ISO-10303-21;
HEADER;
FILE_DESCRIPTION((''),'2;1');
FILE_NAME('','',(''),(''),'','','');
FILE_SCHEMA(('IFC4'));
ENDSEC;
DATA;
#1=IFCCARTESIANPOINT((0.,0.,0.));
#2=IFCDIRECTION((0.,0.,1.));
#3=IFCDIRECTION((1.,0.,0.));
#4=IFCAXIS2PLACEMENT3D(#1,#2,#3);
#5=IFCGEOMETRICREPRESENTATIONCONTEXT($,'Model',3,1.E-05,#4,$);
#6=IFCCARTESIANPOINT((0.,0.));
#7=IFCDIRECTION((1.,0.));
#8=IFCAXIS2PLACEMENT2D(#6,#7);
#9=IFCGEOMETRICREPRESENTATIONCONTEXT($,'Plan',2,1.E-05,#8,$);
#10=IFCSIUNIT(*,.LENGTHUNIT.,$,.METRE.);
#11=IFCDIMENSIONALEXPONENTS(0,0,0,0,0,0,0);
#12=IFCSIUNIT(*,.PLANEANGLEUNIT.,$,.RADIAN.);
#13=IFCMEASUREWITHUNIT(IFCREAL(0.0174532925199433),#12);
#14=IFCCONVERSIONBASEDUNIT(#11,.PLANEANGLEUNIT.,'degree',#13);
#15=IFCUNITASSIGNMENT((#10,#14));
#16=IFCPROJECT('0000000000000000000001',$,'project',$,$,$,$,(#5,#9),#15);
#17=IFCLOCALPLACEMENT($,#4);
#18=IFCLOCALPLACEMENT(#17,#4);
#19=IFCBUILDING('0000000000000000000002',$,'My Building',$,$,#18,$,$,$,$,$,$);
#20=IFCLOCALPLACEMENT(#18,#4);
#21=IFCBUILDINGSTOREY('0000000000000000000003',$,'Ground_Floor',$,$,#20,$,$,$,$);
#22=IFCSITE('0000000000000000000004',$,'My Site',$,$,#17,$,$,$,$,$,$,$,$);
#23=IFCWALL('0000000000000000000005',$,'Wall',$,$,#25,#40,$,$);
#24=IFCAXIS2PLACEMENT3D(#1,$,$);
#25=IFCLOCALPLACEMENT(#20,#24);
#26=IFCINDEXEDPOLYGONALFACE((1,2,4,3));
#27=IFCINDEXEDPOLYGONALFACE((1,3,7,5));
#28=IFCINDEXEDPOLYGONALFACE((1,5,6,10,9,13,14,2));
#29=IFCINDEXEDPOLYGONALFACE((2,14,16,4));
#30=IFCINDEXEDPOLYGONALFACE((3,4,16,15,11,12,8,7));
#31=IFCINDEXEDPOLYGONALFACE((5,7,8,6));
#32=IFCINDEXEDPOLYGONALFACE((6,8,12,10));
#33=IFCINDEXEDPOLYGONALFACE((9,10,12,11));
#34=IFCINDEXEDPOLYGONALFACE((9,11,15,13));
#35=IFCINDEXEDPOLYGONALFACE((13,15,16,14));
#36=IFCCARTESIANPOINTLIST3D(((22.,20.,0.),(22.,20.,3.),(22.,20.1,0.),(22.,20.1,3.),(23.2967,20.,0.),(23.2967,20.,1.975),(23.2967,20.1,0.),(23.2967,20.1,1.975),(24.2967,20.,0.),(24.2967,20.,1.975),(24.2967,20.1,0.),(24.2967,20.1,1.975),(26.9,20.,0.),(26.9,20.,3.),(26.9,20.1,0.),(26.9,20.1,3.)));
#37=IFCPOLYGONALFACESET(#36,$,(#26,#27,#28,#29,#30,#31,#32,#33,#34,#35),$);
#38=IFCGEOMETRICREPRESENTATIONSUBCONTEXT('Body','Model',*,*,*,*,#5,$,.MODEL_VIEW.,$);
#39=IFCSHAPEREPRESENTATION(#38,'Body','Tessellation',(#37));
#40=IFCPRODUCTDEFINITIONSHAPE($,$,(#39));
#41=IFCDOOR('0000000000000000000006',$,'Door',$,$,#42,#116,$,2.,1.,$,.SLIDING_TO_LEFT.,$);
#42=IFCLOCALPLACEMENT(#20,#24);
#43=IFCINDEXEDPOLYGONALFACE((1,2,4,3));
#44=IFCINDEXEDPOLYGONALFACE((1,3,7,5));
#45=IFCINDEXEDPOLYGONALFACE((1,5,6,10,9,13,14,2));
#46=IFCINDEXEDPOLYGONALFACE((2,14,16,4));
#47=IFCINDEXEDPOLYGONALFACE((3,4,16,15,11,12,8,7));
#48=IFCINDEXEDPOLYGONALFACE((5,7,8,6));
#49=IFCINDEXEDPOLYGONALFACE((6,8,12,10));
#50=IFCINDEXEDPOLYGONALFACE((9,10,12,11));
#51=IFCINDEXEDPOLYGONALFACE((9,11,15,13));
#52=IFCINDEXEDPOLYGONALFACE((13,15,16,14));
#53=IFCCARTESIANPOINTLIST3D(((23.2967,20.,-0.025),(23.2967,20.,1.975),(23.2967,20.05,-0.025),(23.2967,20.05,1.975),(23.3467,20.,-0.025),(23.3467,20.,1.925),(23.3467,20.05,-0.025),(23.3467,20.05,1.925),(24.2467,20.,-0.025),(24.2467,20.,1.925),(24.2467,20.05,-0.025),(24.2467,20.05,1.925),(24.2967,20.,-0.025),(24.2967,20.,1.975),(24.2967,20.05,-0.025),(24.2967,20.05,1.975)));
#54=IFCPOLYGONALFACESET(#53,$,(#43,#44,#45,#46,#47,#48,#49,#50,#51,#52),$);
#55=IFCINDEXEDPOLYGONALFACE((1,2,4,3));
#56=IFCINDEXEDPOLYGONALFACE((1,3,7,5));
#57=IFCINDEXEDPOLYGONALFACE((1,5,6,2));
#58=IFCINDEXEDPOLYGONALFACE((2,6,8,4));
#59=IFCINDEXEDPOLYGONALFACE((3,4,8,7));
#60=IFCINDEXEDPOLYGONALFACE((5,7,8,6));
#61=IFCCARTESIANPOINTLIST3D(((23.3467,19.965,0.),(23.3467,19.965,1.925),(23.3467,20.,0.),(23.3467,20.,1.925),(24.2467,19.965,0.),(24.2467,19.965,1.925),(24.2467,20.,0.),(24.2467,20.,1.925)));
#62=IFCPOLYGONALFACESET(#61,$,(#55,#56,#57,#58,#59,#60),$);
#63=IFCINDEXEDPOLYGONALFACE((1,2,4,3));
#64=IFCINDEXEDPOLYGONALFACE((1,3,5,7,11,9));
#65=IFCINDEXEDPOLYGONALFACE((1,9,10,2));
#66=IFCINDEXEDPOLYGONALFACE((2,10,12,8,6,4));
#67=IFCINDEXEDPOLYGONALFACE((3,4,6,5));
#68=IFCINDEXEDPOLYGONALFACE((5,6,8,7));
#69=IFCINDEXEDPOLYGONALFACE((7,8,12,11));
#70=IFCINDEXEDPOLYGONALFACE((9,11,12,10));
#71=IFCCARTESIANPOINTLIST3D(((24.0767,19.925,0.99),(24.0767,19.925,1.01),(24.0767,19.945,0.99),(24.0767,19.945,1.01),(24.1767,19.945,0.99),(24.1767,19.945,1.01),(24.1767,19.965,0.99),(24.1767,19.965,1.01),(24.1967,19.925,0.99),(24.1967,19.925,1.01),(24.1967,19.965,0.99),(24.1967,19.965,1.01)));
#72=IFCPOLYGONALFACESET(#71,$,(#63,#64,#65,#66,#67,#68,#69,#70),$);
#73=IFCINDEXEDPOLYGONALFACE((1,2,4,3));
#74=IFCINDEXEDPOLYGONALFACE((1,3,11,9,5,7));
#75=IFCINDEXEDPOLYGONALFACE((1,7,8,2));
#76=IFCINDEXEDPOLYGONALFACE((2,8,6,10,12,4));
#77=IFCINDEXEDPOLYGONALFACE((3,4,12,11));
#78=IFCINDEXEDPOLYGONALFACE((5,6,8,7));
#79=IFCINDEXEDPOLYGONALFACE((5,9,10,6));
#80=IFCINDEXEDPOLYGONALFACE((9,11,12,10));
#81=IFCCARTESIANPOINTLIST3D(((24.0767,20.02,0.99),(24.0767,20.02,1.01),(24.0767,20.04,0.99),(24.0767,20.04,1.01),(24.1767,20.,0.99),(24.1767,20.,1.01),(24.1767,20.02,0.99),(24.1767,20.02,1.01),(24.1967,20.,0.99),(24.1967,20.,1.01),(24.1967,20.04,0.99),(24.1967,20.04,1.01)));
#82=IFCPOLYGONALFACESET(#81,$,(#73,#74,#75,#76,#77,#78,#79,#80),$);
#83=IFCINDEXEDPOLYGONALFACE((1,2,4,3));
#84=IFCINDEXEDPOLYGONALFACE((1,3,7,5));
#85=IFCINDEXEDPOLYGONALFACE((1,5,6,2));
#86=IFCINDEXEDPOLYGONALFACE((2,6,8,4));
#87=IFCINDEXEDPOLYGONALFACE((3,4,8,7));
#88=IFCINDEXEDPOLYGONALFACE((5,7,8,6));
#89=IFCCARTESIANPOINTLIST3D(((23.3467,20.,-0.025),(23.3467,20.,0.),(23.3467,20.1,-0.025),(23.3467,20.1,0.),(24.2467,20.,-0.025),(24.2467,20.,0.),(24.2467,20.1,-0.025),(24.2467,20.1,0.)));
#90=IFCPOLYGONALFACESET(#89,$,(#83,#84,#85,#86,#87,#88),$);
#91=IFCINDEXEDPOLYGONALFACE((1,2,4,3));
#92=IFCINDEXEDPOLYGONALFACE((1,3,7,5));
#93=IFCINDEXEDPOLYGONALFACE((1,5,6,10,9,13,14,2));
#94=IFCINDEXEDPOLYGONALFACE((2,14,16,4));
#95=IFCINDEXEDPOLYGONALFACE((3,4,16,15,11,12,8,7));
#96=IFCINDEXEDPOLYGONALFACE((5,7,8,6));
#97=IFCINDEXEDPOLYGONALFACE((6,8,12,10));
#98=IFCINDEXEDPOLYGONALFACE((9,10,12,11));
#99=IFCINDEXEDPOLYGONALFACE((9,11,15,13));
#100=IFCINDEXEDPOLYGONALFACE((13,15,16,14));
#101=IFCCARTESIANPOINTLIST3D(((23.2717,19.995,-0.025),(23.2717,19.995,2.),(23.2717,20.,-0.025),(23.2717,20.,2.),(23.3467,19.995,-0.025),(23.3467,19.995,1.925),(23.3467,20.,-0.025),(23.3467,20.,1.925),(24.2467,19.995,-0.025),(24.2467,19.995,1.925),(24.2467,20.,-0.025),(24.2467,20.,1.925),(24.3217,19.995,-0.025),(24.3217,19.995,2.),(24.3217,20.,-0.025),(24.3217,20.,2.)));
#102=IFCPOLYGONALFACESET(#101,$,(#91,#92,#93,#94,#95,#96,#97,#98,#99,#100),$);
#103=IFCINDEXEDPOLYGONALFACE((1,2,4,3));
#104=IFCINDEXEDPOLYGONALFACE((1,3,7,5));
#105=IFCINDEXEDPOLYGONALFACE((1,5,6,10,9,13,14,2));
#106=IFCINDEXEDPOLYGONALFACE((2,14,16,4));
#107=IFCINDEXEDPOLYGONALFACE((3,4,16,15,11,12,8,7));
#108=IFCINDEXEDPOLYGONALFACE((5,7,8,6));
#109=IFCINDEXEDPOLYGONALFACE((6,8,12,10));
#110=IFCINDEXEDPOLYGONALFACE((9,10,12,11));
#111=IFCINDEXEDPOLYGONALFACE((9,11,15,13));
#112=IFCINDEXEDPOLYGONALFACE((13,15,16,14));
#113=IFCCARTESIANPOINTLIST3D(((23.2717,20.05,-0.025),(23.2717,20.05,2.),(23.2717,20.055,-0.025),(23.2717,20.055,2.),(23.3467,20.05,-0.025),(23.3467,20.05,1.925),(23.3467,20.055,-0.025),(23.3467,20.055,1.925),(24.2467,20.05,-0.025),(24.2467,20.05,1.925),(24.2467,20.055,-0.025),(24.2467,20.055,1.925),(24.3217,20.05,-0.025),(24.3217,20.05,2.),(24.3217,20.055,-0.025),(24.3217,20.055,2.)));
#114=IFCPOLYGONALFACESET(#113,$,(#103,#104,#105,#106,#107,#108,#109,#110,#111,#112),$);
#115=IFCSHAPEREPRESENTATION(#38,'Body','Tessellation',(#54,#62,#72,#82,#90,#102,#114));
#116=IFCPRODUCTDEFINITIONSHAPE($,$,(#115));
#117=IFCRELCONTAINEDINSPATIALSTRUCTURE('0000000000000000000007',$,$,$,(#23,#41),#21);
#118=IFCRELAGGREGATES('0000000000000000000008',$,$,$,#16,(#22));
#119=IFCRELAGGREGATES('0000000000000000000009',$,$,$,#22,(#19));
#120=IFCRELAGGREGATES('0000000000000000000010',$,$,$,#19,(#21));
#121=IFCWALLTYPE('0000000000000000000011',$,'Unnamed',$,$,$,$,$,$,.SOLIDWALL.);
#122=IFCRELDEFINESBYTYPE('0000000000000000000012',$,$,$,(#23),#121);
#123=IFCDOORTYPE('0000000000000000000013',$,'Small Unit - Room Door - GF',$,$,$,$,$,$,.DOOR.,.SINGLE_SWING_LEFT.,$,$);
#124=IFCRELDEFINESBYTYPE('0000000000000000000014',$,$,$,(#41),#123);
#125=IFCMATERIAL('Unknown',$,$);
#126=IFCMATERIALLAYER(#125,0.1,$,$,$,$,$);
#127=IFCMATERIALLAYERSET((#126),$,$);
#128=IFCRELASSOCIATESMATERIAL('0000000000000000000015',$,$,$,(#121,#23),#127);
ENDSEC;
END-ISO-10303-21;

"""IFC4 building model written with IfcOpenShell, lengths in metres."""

from ifc_helpers import new_model, entity, si_unit, converted_unit, frame, origin_with_axes, origin_2d_with_axis, place, context, subcontext, project, spatial, line, indexed_curve, outline, extrude, shape, source, transform, mapped, material, layer, layer_set, layer_usage, type_object, type_shapes, element, fill, save


model = new_model("IFC4")

# Units and contexts
model_context = context("Model", 3, precision=1e-05, world=origin_with_axes())
plan_context = context("Plan", 2, precision=1e-05, world=origin_2d_with_axis())
body_context_1 = subcontext(model_context, "Body", "Model", "MODEL_VIEW")
body_context_2 = subcontext(plan_context, "Body", "Plan", "PLAN_VIEW")
ifc_project = project(units=[si_unit("LENGTHUNIT", "METRE"), converted_unit("PLANEANGLEUNIT", "degree", entity("IfcReal", 0.0174532925199433), si_unit("PLANEANGLEUNIT", "RADIAN"), dimensions=[0, 0, 0, 0, 0, 0, 0])], contexts=[model_context, plan_context])

# Site, building, storey
site_placement = place(None, origin_with_axes())
site = spatial("IfcSite", under=ifc_project, at=site_placement, Name="My Site")
building_placement = place(site_placement, origin_with_axes())
building = spatial("IfcBuilding", under=site, at=building_placement, Name="My Building")
storey_placement = place(building_placement, origin_with_axes())
storey = spatial("IfcBuildingStorey", under=building, at=storey_placement, Name="Ground_Floor")

# Shared definitions
ifc_material = material(Name="Unknown")
ifc_layer = layer(ifc_material, 0.1)
ifc_layer_set = layer_set([ifc_layer])
wall_type = type_object("IfcWallType", Name="Unnamed", PredefinedType="SOLIDWALL", material=ifc_layer_set)

# Shared definitions
shared_shape_1 = source(origin_with_axes(), body_context_1, "Body", "SweptSolid", [
    extrude(outline(indexed_curve([(0.0, 0.0), (1.0, 0.0), (1.0, 2.0), (0.0, 2.0)], segments=[line(1, 2, 3, 4, 1)])), frame((0.0, -0.6, 0.0), z_axis=(0.0, -1.0, 0.0), x_axis=(1.0, 0.0, 0.0)), (0.0, 0.0, -1.0), 1.2),
])
door_type_1 = type_object("IfcDoorType", Name="Small Unit - Room Door - GF", OperationType="SINGLE_SWING_LEFT", PredefinedType="DOOR")
shared_shape_2 = source(origin_with_axes(), body_context_1, "Body", "SweptSolid", [
    extrude(outline(indexed_curve([(0.0, 0.0), (0.0, 2.0), (1.0, 2.0), (1.0, 0.0), (0.95, 0.0), (0.95, 1.95), (0.05, 1.95), (0.05, 0.0)], segments=[line(1, 2, 3, 4, 5, 6, 7, 8, 1)])), frame((0.0, 0.0, 0.0), z_axis=(0.0, -1.0, 0.0), x_axis=(1.0, 0.0, 0.0)), (0.0, 0.0, -1.0), 0.05),
    extrude(outline(indexed_curve([(0.0, 0.0), (0.9, 0.0), (0.9, 0.035), (0.0, 0.035)], segments=[line(1, 2, 3, 4, 1)])), frame((0.05, -0.035, 0.025), z_axis=(0.0, 0.0, 1.0), x_axis=(1.0, 0.0, 0.0)), (0.0, 0.0, 1.0), 1.925),
    extrude(outline(indexed_curve([(0.0, 0.0), (0.0, -0.04), (-0.12, -0.04), (-0.12, -0.02), (-0.02, -0.02), (-0.02, 0.0)], segments=[line(1, 2, 3, 4, 5, 6, 1)])), frame((0.9, -0.035, 1.015), z_axis=(0.0, 0.0, 1.0), x_axis=(1.0, 0.0, 0.0)), (0.0, 0.0, 1.0), 0.02),
    extrude(outline(indexed_curve([(0.0, 0.0), (0.0, 0.04), (-0.12, 0.04), (-0.12, 0.02), (-0.02, 0.02), (-0.02, 0.0)], segments=[line(1, 2, 3, 4, 5, 6, 1)])), frame((0.9, 0.0, 1.015), z_axis=(0.0, 0.0, 1.0), x_axis=(1.0, 0.0, 0.0)), (0.0, 0.0, 1.0), 0.02),
    extrude(outline(indexed_curve([(0.0, 0.0), (0.9, 0.0), (0.9, 0.1), (0.0, 0.1)], segments=[line(1, 2, 3, 4, 1)])), frame((0.05, 0.0, 0.0), z_axis=(0.0, 0.0, 1.0), x_axis=(1.0, 0.0, 0.0)), (0.0, 0.0, 1.0), 0.025),
    extrude(outline(indexed_curve([(0.0, 0.0), (0.0, 2.025), (1.05, 2.025), (1.05, 0.0), (0.975, 0.0), (0.975, 1.95), (0.075, 1.95), (0.075, 0.0)], segments=[line(1, 2, 3, 4, 5, 6, 7, 8, 1)])), frame((-0.025, -0.005, 0.0), z_axis=(0.0, -1.0, 0.0), x_axis=(1.0, 0.0, 0.0)), (0.0, 0.0, -1.0), 0.005),
    extrude(outline(indexed_curve([(0.0, 0.0), (0.0, 2.025), (1.05, 2.025), (1.05, 0.0), (0.975, 0.0), (0.975, 1.95), (0.075, 1.95), (0.075, 0.0)], segments=[line(1, 2, 3, 4, 5, 6, 7, 8, 1)])), frame((-0.025, 0.05, 0.0), z_axis=(0.0, -1.0, 0.0), x_axis=(1.0, 0.0, 0.0)), (0.0, 0.0, -1.0), 0.005),
])
shared_shape_3 = source(origin_with_axes(), body_context_2, "Body", "Curve2D", [
    entity("IfcIndexedPolyCurve", entity("IfcCartesianPointList2D", [[0.0, 0.0], [0.05, 0.0], [0.05, 0.05], [0.0, 0.05]]), [entity("IfcLineIndex", [1, 2, 3, 4, 1])]),
    entity("IfcIndexedPolyCurve", entity("IfcCartesianPointList2D", [[1.0, 0.0], [0.95, 0.0], [0.95, 0.05], [1.0, 0.05]]), [entity("IfcLineIndex", [1, 2, 3, 4, 1])]),
    entity("IfcIndexedPolyCurve", entity("IfcCartesianPointList2D", [[-0.4, -0.035], [0.5, -0.035], [0.5, 0.0], [-0.4, 0.0]]), [entity("IfcLineIndex", [1, 2, 3, 4, 1])]),
])
type_shapes(door_type_1, [shared_shape_2, shared_shape_3])

# Wall, opening, door
ifc_layer_usage_1 = layer_usage(ifc_layer_set, "AXIS2", "POSITIVE", 0.0)
wall_1_placement = place(storey_placement, frame((22.0, 20.0, 0.0), z_axis=(0.0, 0.0, 1.0), x_axis=(1.0, 0.0, 0.0)))
wall_1 = element("IfcWall", 1, at=wall_1_placement, inside=storey, type_object=wall_type, material=ifc_layer_usage_1, Name="Wall", context=body_context_1, shape_type="SweptSolid", body=[
    extrude(outline(indexed_curve([(0.0, 0.0), (0.0, 0.1), (4.9, 0.1), (4.9, 0.0)], segments=[line(1, 2, 3, 4, 1)])), origin_with_axes(), (0.0, 0.0, 1.0), 3.0),
])
opening_1_placement = place(wall_1_placement, frame((1.2967, 0.0, -0.025), z_axis=(0.0, 0.0, 1.0), x_axis=(1.0, 0.0, 0.0)))
opening_1 = element("IfcOpeningElement", 2, at=opening_1_placement, cuts=wall_1, PredefinedType="OPENING", context=body_context_1, shape_type="MappedRepresentation", body=[
    mapped(shared_shape_1, transform((0.0, 0.0, 0.0), x_axis=(1.0, 0.0, 0.0), y_axis=(0.0, 1.0, 0.0), z_axis=(0.0, 0.0, 1.0), scale=1.0)),
])
door_1_placement = place(opening_1_placement, frame((0.0, 0.0, 0.0), z_axis=(0.0, 0.0, 1.0), x_axis=(1.0, 0.0, 0.0)))
door_1 = element("IfcDoor", 3, at=door_1_placement, inside=storey, type_object=door_type_1, Name="Door", OperationType="SLIDING_TO_LEFT", OverallHeight=2.0, OverallWidth=1.0, shapes=[
    shape(body_context_1, "Body", "MappedRepresentation", [mapped(shared_shape_2, transform((0.0, 0.0, 0.0), x_axis=(1.0, 0.0, 0.0), y_axis=(0.0, 1.0, 0.0), z_axis=(0.0, 0.0, 1.0), scale=1.0))]),
    shape(body_context_2, "Body", "MappedRepresentation", [mapped(shared_shape_3, transform((0.0, 0.0, 0.0), x_axis=(1.0, 0.0, 0.0), y_axis=(0.0, 1.0, 0.0), z_axis=(0.0, 0.0, 1.0), scale=1.0))]),
])
fill(opening_1, door_1)

save(model, "model.ifc")
